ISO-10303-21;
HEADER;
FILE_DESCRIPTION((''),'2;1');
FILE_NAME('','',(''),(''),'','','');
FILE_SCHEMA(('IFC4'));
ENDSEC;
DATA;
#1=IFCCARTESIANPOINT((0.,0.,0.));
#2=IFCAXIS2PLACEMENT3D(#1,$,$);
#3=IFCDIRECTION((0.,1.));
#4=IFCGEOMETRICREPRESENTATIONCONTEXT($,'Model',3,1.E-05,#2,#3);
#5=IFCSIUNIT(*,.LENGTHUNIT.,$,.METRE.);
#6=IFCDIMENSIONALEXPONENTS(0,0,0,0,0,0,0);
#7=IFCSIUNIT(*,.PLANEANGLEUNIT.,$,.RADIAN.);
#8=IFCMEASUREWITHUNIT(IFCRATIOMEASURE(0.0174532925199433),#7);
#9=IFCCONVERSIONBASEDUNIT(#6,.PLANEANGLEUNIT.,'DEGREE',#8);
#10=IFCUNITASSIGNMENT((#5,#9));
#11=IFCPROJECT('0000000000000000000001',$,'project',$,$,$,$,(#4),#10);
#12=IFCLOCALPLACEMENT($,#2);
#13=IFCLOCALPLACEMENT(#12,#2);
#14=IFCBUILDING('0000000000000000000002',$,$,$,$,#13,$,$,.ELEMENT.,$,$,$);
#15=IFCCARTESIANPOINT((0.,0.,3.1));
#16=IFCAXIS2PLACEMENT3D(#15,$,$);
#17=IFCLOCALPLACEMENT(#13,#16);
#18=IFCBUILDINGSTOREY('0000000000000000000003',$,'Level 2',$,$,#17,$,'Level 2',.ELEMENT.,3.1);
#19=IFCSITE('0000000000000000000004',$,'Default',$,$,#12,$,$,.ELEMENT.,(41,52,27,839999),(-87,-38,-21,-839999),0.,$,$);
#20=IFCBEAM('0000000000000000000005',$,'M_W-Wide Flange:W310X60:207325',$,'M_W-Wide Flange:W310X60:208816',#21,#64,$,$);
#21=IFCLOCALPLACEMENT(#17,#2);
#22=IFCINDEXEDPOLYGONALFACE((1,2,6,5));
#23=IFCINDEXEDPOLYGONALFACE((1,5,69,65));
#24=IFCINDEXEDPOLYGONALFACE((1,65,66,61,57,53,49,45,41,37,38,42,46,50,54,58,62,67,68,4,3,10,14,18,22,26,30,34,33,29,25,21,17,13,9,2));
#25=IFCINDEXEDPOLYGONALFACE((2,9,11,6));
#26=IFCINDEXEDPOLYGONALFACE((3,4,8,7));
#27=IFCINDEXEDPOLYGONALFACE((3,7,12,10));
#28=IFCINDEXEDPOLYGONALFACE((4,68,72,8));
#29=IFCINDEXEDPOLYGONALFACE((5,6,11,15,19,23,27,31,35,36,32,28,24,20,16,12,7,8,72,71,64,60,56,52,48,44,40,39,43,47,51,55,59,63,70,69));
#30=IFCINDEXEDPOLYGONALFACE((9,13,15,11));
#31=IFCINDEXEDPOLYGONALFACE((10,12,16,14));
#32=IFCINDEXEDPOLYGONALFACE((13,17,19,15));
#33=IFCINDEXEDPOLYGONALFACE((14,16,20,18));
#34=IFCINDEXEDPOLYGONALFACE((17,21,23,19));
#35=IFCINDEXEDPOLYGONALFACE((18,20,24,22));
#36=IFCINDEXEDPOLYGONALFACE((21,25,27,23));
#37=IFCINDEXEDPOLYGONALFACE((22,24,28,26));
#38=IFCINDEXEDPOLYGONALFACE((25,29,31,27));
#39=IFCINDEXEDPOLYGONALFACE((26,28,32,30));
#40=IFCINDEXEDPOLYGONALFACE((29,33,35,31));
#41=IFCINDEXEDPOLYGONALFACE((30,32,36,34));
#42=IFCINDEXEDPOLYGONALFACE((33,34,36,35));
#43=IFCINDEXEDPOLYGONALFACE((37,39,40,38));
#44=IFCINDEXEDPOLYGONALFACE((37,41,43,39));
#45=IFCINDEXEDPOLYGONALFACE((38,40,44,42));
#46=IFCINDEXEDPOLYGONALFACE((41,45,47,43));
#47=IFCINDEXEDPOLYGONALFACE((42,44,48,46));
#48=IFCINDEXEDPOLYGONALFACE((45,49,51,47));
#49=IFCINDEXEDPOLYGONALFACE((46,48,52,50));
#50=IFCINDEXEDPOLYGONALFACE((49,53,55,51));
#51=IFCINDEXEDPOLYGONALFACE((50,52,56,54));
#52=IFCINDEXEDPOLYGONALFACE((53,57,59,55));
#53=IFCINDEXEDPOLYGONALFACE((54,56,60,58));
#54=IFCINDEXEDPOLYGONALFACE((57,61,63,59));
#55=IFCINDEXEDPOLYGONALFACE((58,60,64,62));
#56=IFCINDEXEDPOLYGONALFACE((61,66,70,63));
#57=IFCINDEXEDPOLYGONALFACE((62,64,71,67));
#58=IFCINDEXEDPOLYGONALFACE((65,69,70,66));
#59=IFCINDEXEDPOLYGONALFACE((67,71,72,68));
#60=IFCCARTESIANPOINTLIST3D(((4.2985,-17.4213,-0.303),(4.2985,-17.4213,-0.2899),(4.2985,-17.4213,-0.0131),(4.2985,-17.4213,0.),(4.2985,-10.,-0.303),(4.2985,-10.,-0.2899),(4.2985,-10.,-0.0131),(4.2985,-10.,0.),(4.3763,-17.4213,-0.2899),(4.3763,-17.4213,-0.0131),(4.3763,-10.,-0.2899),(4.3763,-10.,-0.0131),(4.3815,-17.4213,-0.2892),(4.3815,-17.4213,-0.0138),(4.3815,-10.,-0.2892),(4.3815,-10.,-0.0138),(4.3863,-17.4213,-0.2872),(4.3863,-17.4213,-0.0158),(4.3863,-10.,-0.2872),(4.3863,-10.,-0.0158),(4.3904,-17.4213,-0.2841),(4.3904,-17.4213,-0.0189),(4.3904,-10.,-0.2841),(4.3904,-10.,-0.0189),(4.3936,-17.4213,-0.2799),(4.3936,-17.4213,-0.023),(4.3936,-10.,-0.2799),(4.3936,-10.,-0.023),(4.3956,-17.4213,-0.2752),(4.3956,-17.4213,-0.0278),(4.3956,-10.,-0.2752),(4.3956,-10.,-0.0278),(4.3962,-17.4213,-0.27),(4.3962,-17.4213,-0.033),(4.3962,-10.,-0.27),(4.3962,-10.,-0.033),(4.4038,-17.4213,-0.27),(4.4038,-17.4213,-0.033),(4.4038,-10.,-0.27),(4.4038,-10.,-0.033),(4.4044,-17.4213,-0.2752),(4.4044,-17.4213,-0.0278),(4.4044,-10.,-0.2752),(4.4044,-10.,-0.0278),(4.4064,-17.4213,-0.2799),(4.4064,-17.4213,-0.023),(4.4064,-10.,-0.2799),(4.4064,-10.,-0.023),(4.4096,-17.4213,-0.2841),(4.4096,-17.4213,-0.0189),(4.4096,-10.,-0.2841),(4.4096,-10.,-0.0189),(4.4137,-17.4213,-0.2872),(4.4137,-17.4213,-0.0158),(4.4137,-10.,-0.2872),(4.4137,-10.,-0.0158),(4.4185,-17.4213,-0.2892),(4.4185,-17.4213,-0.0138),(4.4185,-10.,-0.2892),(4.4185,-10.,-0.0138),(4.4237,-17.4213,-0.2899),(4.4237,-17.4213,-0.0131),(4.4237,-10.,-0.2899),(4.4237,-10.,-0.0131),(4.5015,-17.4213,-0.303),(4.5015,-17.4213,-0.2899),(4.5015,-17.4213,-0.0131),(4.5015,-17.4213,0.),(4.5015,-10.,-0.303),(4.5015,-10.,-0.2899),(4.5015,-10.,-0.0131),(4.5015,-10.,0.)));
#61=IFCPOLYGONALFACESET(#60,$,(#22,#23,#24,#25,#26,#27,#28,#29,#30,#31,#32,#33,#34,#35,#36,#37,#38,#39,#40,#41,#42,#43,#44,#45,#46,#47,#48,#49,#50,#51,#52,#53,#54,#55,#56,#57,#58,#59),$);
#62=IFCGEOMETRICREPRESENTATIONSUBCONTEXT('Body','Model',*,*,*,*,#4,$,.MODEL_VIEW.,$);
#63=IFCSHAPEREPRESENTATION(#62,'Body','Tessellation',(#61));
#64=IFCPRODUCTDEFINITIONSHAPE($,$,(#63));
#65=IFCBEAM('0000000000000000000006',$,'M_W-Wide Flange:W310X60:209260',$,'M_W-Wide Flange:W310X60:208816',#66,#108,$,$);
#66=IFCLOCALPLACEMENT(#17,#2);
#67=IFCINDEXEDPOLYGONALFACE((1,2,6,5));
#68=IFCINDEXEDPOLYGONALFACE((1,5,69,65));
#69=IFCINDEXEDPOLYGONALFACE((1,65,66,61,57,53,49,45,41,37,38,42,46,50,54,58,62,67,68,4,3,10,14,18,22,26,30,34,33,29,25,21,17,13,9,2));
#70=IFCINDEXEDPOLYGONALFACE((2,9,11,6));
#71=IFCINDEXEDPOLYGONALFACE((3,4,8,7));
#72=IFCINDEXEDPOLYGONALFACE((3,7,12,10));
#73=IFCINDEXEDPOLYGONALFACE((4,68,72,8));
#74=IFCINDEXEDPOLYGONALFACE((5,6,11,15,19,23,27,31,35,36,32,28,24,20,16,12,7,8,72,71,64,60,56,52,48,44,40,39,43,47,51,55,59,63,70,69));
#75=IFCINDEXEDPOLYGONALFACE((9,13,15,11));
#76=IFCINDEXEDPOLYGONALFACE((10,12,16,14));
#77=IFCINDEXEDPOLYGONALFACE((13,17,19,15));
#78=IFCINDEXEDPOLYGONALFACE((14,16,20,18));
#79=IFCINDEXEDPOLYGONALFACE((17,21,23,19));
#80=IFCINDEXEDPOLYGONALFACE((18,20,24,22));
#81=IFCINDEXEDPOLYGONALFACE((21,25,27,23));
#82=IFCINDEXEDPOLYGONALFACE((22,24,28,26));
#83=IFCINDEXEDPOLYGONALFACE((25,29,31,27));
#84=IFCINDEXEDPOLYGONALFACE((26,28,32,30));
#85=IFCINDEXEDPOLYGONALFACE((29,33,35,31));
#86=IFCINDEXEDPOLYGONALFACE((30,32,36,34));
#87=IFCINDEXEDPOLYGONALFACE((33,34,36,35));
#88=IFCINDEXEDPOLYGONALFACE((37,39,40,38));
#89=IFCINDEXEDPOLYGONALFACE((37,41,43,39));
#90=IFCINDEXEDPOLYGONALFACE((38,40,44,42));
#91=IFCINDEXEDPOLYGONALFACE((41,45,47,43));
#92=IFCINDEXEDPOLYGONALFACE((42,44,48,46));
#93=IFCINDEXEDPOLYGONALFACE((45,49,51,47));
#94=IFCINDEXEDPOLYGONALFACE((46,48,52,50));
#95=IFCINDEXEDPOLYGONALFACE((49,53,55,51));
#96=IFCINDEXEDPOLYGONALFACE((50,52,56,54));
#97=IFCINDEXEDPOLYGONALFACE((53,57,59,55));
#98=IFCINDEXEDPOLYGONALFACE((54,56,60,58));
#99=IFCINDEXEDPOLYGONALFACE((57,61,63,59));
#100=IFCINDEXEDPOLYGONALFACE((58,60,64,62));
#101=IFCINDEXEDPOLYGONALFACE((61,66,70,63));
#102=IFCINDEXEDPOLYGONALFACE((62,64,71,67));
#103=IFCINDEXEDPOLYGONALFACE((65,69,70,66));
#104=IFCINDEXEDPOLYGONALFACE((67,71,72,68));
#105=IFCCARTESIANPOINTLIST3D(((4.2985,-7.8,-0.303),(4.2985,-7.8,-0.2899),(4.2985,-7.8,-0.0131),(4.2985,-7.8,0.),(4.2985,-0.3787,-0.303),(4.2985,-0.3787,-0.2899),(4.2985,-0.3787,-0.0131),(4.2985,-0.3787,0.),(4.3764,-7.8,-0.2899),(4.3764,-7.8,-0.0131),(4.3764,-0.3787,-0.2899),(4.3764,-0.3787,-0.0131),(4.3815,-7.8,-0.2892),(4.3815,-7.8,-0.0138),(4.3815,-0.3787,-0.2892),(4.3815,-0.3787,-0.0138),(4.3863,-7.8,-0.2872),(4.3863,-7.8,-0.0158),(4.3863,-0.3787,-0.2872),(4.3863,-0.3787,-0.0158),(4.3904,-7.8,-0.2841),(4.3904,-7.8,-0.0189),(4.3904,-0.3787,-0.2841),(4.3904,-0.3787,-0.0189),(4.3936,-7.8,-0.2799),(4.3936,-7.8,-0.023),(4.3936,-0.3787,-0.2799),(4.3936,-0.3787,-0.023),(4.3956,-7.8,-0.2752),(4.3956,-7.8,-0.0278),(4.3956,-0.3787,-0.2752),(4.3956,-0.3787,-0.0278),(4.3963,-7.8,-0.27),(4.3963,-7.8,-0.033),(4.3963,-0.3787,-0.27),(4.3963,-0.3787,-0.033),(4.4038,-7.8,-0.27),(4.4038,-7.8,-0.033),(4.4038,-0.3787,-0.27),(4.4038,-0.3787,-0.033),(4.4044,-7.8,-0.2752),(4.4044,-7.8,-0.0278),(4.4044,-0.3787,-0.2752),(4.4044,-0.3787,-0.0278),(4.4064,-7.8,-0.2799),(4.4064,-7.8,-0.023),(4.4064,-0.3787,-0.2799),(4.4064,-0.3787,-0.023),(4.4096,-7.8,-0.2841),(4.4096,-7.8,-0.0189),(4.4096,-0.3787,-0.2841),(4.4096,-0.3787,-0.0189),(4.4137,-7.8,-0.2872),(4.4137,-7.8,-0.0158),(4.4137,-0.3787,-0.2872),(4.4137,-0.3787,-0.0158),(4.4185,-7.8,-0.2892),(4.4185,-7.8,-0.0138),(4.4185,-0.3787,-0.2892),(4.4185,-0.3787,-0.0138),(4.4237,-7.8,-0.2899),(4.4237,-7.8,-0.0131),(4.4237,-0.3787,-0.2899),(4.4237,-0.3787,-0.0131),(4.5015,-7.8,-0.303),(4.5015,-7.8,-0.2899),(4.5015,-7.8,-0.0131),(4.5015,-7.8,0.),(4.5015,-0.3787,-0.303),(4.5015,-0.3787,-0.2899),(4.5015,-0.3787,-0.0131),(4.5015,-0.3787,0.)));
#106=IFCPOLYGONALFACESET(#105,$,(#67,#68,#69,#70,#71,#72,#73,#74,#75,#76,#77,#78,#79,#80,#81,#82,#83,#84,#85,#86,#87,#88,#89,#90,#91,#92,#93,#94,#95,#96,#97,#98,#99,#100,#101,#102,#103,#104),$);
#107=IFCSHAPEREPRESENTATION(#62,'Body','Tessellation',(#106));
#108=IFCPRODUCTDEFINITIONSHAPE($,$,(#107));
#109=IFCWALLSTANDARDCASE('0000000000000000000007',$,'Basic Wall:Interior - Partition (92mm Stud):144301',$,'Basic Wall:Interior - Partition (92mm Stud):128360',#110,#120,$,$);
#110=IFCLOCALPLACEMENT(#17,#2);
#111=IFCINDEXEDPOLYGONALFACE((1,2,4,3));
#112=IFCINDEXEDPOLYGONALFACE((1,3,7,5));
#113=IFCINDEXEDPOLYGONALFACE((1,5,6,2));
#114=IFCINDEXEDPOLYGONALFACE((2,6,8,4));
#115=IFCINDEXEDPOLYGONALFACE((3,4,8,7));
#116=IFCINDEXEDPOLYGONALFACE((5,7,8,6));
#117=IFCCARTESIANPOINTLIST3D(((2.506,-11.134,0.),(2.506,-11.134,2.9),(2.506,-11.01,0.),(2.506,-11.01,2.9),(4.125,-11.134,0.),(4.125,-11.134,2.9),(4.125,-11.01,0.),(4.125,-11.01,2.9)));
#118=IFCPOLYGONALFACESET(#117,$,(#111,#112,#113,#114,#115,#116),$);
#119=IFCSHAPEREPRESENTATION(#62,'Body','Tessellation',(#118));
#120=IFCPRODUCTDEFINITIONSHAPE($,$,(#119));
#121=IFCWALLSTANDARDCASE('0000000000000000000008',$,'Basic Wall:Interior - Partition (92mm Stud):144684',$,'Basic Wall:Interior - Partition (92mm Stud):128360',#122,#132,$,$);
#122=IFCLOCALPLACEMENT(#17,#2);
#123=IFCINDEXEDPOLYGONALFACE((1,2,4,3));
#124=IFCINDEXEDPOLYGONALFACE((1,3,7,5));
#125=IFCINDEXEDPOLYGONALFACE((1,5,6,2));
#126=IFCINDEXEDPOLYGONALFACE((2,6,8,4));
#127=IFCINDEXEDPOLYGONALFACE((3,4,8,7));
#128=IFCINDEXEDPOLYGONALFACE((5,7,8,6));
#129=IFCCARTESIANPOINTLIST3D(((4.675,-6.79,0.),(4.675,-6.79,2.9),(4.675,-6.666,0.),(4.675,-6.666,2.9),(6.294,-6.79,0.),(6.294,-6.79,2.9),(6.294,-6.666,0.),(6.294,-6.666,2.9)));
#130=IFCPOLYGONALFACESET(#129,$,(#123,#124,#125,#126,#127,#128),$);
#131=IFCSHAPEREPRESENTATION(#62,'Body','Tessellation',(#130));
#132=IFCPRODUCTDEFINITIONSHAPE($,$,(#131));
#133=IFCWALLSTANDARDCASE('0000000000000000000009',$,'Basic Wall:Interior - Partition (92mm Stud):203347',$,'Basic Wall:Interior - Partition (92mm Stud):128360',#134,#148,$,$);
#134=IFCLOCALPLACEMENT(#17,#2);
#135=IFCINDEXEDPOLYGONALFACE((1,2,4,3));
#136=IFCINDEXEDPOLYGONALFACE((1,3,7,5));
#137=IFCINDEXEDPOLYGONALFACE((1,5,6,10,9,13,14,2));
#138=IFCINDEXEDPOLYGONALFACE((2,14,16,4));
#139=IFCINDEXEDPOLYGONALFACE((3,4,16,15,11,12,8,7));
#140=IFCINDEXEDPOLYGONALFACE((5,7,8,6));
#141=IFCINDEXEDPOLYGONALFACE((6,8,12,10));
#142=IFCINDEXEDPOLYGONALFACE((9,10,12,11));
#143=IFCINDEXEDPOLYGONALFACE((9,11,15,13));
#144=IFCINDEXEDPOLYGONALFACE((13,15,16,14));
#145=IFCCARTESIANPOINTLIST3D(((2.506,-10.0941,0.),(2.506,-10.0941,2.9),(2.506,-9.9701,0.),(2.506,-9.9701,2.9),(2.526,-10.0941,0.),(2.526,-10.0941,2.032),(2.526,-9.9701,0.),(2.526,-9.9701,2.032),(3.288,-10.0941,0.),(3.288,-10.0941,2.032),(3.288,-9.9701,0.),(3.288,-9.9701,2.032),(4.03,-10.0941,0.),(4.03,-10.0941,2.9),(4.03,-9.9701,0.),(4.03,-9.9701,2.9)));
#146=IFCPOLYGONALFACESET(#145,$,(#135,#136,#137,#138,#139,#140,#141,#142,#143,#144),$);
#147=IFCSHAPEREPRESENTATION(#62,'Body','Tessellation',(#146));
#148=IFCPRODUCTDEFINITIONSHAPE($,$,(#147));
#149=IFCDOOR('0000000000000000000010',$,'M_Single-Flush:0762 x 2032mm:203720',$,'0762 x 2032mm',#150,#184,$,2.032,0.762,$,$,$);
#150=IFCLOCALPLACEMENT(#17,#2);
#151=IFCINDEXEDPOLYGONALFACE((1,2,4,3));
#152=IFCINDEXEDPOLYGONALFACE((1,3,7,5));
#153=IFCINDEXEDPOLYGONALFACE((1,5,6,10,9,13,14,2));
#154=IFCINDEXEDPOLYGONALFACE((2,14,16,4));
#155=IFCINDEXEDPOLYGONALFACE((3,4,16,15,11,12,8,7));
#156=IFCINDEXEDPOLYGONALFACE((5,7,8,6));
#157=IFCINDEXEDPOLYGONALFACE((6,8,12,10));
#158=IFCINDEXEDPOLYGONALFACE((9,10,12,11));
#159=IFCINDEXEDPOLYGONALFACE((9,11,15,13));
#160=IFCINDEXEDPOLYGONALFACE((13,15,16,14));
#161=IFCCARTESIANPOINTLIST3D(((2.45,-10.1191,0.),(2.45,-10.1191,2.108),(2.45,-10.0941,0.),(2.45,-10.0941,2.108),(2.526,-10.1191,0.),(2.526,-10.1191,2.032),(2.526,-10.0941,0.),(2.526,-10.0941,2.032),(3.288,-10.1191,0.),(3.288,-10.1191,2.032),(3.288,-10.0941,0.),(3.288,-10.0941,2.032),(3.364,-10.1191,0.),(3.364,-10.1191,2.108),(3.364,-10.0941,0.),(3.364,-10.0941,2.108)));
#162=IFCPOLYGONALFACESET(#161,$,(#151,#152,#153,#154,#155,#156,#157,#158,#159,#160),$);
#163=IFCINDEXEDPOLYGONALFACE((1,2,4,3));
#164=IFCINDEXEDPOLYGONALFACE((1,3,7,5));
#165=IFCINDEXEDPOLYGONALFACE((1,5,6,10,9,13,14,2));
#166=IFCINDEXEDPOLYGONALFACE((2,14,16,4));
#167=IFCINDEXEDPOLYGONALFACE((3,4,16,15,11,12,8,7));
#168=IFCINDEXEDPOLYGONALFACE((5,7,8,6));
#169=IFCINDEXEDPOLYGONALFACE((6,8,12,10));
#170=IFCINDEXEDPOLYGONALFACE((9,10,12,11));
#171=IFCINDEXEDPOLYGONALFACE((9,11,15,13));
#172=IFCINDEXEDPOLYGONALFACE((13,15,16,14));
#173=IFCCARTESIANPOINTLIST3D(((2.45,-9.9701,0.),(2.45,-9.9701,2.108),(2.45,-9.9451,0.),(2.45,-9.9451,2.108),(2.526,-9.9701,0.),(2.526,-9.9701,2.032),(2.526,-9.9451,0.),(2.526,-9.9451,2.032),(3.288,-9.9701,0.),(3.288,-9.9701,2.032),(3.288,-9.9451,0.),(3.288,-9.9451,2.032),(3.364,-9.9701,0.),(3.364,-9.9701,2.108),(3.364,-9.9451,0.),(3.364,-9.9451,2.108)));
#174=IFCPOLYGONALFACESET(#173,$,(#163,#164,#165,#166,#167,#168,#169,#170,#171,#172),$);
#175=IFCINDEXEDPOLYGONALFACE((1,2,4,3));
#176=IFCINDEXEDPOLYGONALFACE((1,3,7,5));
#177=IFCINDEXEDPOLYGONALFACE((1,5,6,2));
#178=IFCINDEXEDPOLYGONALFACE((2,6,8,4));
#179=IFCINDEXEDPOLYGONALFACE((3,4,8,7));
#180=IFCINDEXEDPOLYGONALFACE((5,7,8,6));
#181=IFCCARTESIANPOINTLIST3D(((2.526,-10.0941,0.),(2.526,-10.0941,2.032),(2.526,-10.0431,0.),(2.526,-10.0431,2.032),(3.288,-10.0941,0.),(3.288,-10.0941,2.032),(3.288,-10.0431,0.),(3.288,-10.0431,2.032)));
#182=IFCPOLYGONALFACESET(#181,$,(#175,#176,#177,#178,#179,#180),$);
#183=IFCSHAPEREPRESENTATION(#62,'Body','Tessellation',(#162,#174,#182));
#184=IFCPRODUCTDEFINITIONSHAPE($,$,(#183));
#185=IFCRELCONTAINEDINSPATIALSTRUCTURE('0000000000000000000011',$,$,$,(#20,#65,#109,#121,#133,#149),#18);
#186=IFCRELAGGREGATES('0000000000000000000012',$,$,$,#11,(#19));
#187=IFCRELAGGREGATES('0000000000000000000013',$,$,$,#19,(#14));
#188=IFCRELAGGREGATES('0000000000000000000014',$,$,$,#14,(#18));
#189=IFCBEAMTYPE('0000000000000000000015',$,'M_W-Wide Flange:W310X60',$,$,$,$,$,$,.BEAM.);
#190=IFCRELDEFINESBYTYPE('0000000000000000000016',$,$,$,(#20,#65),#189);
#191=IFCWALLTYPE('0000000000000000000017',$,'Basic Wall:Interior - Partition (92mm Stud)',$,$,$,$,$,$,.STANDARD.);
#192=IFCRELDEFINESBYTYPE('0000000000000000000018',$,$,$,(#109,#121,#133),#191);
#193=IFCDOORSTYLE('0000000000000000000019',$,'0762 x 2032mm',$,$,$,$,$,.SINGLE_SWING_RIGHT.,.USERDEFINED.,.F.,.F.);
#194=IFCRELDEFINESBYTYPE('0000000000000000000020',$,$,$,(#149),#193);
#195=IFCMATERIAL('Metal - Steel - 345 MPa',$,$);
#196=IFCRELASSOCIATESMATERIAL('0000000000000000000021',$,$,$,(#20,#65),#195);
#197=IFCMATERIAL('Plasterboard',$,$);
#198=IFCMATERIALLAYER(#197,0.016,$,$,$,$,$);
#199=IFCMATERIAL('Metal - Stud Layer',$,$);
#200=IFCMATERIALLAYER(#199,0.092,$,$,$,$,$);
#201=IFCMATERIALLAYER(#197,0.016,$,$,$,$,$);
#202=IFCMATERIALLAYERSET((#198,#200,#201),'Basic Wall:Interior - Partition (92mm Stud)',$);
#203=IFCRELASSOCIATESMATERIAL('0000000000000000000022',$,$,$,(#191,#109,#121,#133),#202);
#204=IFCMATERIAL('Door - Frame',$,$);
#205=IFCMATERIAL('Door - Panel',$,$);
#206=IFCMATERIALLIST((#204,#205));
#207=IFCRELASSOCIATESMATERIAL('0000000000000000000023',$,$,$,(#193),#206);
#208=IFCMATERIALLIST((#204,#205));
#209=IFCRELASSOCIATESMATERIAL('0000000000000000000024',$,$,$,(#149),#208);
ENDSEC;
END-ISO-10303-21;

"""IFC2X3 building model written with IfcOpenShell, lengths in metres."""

from ifc_helpers import new_model, entity, si_unit, converted_unit, direction, frame, frame_2d, origin, origin_2d_with_axis, place, context, subcontext, project, spatial, polyline, rectangle, i_section, outline, extrude, source, transform, mapped, material, material_list, layer, layer_set, layer_usage, type_object, type_shapes, element, fill, save


model = new_model("IFC2X3")

# Units and contexts
model_context = context("Model", 3, precision=1e-05, world=origin(), true_north=direction((0.0, 1.0)))
body_context = subcontext(model_context, "Body", "Model", "MODEL_VIEW")
ifc_project = project(units=[si_unit("LENGTHUNIT", "METRE"), converted_unit("PLANEANGLEUNIT", "DEGREE", entity("IfcRatioMeasure", 0.0174532925199433), si_unit("PLANEANGLEUNIT", "RADIAN"), dimensions=[0, 0, 0, 0, 0, 0, 0])], contexts=[model_context])

# Site, building, storey
site_placement = place(None, origin())
site = spatial("IfcSite", under=ifc_project, at=site_placement, Name="Default", CompositionType="ELEMENT", RefLatitude=(41, 52, 27, 839999), RefLongitude=(-87, -38, -21, -839999), RefElevation=0.0)
building_placement = place(site_placement, origin())
building = spatial("IfcBuilding", under=site, at=building_placement, CompositionType="ELEMENT")
storey_placement = place(building_placement, frame((0.0, 0.0, 3.1)))
storey = spatial("IfcBuildingStorey", under=building, at=storey_placement, Name="Level 2", LongName="Level 2", CompositionType="ELEMENT", Elevation=3.1)

# Beams
ifc_material_1 = material(Name="Metal - Steel - 345 MPa")
beam_type = type_object("IfcBeamType", Name="M_W-Wide Flange:W310X60", PredefinedType="BEAM")
beam_1_placement = place(storey_placement, frame((4.4, -10.0, 0.0), z_axis=(0.0, 0.0, 1.0), x_axis=(0.0, -1.0, 0.0)))
element("IfcBeam", 1, at=beam_1_placement, inside=storey, type_object=beam_type, material=ifc_material_1, Name="M_W-Wide Flange:W310X60:207325", ObjectType="M_W-Wide Flange:W310X60:208816", context=body_context, shape_type="SweptSolid", body=[
    extrude(i_section(OverallWidth=0.203, OverallDepth=0.303, WebThickness=0.0075, FlangeThickness=0.0131, FilletRadius=0.0199, at=frame_2d((0.0, 0.0), x_axis=(0.0, 1.0))), frame((0.0, 0.0, -0.1515), z_axis=(1.0, 0.0, 0.0), x_axis=(0.0, 0.0, -1.0)), (0.0, 0.0, 1.0), 7.4213),
])
beam_2_placement = place(storey_placement, frame((4.4, -7.8, 0.0), z_axis=(0.0, 0.0, 1.0), x_axis=(0.0, 1.0, 0.0)))
element("IfcBeam", 2, at=beam_2_placement, inside=storey, type_object=beam_type, material=ifc_material_1, Name="M_W-Wide Flange:W310X60:209260", ObjectType="M_W-Wide Flange:W310X60:208816", context=body_context, shape_type="SweptSolid", body=[
    extrude(i_section(OverallWidth=0.203, OverallDepth=0.303, WebThickness=0.0075, FlangeThickness=0.0131, FilletRadius=0.0199, at=frame_2d((0.0, 0.0), x_axis=(0.0, 1.0))), frame((0.0, 0.0, -0.1515), z_axis=(1.0, 0.0, 0.0), x_axis=(0.0, 0.0, -1.0)), (0.0, 0.0, 1.0), 7.4213),
])

# Walls
ifc_material_2 = material(Name="Plasterboard")
ifc_layer_1 = layer(ifc_material_2, 0.016)
ifc_material_3 = material(Name="Metal - Stud Layer")
ifc_layer_2 = layer(ifc_material_3, 0.092)
ifc_layer_3 = layer(ifc_material_2, 0.016)
ifc_layer_set_1 = layer_set([ifc_layer_1, ifc_layer_2, ifc_layer_3], Name="Basic Wall:Interior - Partition (92mm Stud)")
ifc_layer_usage_1 = layer_usage(ifc_layer_set_1, "AXIS2", "NEGATIVE", 0.062)
wall_type_1 = type_object("IfcWallType", Name="Basic Wall:Interior - Partition (92mm Stud)", PredefinedType="STANDARD", material=ifc_layer_set_1)
wall_1_placement = place(storey_placement, frame((4.125, -11.072, 0.0), z_axis=(0.0, 0.0, 1.0), x_axis=(-1.0, 0.0, 0.0)))
element("IfcWallStandardCase", 3, at=wall_1_placement, inside=storey, type_object=wall_type_1, material=ifc_layer_usage_1, Name="Basic Wall:Interior - Partition (92mm Stud):144301", ObjectType="Basic Wall:Interior - Partition (92mm Stud):128360", context=body_context, shape_type="SweptSolid", body=[
    extrude(rectangle(XDim=1.619, YDim=0.124, at=frame_2d((0.8095, 0.0), x_axis=(-1.0, 0.0))), origin(), (0.0, 0.0, 1.0), 2.9),
])
ifc_layer_usage_2 = layer_usage(ifc_layer_set_1, "AXIS2", "NEGATIVE", 0.062)
wall_2_placement = place(storey_placement, frame((4.675, -6.728, 0.0)))
element("IfcWallStandardCase", 4, at=wall_2_placement, inside=storey, type_object=wall_type_1, material=ifc_layer_usage_2, Name="Basic Wall:Interior - Partition (92mm Stud):144684", ObjectType="Basic Wall:Interior - Partition (92mm Stud):128360", context=body_context, shape_type="SweptSolid", body=[
    extrude(rectangle(XDim=1.619, YDim=0.124, at=frame_2d((0.8095, 0.0), x_axis=(-1.0, 0.0))), origin(), (0.0, 0.0, 1.0), 2.9),
])

# Wall, opening, door
ifc_layer_usage_3 = layer_usage(ifc_layer_set_1, "AXIS2", "NEGATIVE", 0.062)
wall_3_placement = place(storey_placement, frame((4.03, -10.0321, 0.0), z_axis=(0.0, 0.0, 1.0), x_axis=(-1.0, 0.0, 0.0)))
wall_3 = element("IfcWallStandardCase", 5, at=wall_3_placement, inside=storey, type_object=wall_type_1, material=ifc_layer_usage_3, Name="Basic Wall:Interior - Partition (92mm Stud):203347", ObjectType="Basic Wall:Interior - Partition (92mm Stud):128360", context=body_context, shape_type="SweptSolid", body=[
    extrude(rectangle(XDim=1.524, YDim=0.124, at=frame_2d((0.762, 0.0), x_axis=(-1.0, 0.0))), origin(), (0.0, 0.0, 1.0), 2.9),
])
opening_1_placement = place(wall_3_placement, frame((0.742, -0.062, 0.0)))
opening_1 = element("IfcOpeningElement", 6, at=opening_1_placement, cuts=wall_3, ObjectType="Opening", context=body_context, shape_type="SweptSolid", body=[
    extrude(rectangle(XDim=0.762, YDim=2.032, at=frame_2d((1.016, 0.381), x_axis=(0.0, 1.0))), frame((0.0, 0.0, 0.0), z_axis=(0.0, 1.0, 0.0), x_axis=(0.0, 0.0, 1.0)), (0.0, 0.0, 1.0), 0.124),
])
ifc_material_4 = material(Name="Door - Frame")
ifc_material_5 = material(Name="Door - Panel")
ifc_material_list_1 = material_list([ifc_material_4, ifc_material_5])
ifc_material_list_2 = material_list([ifc_material_4, ifc_material_5])
door_style = type_object("IfcDoorStyle", Name="0762 x 2032mm", ConstructionType="USERDEFINED", OperationType="SINGLE_SWING_RIGHT", ParameterTakesPrecedence=False, Sizeable=False, material=ifc_material_list_2)
shared_shape_1 = source(origin(), body_context, "Body", "SweptSolid", [
    extrude(outline(polyline([(-0.457, -1.073), (0.457, -1.073), (0.457, 1.035), (0.381, 1.035), (0.381, -0.997), (-0.381, -0.997), (-0.381, 1.035), (-0.457, 1.035), (-0.457, -1.073)])), frame((0.381, 0.124, 1.035), z_axis=(0.0, 1.0, 0.0), x_axis=(1.0, 0.0, 0.0)), (0.0, 0.0, 1.0), 0.025),
    extrude(outline(polyline([(-1.073, -0.457), (1.035, -0.457), (1.035, -0.381), (-0.997, -0.381), (-0.997, 0.381), (1.035, 0.381), (1.035, 0.457), (-1.073, 0.457), (-1.073, -0.457)])), frame((0.381, -0.025, 1.035), z_axis=(0.0, 1.0, 0.0), x_axis=(0.0, 0.0, -1.0)), (0.0, 0.0, 1.0), 0.025),
    extrude(rectangle(XDim=0.051, YDim=0.762, at=origin_2d_with_axis()), frame((0.381, 0.0985, 0.0), z_axis=(0.0, 0.0, 1.0), x_axis=(0.0, 1.0, 0.0)), (0.0, 0.0, 1.0), 2.032),
])
type_shapes(door_style, [shared_shape_1])
door_1_placement = place(opening_1_placement, origin())
door_1 = element("IfcDoor", 7, at=door_1_placement, inside=storey, type_object=door_style, material=ifc_material_list_1, Name="M_Single-Flush:0762 x 2032mm:203720", ObjectType="0762 x 2032mm", OverallHeight=2.032, OverallWidth=0.762, context=body_context, shape_type="MappedRepresentation", body=[
    mapped(shared_shape_1, transform((0.0, 0.0, 0.0), scale=1.0)),
])
fill(opening_1, door_1)

save(model, "model.ifc")
